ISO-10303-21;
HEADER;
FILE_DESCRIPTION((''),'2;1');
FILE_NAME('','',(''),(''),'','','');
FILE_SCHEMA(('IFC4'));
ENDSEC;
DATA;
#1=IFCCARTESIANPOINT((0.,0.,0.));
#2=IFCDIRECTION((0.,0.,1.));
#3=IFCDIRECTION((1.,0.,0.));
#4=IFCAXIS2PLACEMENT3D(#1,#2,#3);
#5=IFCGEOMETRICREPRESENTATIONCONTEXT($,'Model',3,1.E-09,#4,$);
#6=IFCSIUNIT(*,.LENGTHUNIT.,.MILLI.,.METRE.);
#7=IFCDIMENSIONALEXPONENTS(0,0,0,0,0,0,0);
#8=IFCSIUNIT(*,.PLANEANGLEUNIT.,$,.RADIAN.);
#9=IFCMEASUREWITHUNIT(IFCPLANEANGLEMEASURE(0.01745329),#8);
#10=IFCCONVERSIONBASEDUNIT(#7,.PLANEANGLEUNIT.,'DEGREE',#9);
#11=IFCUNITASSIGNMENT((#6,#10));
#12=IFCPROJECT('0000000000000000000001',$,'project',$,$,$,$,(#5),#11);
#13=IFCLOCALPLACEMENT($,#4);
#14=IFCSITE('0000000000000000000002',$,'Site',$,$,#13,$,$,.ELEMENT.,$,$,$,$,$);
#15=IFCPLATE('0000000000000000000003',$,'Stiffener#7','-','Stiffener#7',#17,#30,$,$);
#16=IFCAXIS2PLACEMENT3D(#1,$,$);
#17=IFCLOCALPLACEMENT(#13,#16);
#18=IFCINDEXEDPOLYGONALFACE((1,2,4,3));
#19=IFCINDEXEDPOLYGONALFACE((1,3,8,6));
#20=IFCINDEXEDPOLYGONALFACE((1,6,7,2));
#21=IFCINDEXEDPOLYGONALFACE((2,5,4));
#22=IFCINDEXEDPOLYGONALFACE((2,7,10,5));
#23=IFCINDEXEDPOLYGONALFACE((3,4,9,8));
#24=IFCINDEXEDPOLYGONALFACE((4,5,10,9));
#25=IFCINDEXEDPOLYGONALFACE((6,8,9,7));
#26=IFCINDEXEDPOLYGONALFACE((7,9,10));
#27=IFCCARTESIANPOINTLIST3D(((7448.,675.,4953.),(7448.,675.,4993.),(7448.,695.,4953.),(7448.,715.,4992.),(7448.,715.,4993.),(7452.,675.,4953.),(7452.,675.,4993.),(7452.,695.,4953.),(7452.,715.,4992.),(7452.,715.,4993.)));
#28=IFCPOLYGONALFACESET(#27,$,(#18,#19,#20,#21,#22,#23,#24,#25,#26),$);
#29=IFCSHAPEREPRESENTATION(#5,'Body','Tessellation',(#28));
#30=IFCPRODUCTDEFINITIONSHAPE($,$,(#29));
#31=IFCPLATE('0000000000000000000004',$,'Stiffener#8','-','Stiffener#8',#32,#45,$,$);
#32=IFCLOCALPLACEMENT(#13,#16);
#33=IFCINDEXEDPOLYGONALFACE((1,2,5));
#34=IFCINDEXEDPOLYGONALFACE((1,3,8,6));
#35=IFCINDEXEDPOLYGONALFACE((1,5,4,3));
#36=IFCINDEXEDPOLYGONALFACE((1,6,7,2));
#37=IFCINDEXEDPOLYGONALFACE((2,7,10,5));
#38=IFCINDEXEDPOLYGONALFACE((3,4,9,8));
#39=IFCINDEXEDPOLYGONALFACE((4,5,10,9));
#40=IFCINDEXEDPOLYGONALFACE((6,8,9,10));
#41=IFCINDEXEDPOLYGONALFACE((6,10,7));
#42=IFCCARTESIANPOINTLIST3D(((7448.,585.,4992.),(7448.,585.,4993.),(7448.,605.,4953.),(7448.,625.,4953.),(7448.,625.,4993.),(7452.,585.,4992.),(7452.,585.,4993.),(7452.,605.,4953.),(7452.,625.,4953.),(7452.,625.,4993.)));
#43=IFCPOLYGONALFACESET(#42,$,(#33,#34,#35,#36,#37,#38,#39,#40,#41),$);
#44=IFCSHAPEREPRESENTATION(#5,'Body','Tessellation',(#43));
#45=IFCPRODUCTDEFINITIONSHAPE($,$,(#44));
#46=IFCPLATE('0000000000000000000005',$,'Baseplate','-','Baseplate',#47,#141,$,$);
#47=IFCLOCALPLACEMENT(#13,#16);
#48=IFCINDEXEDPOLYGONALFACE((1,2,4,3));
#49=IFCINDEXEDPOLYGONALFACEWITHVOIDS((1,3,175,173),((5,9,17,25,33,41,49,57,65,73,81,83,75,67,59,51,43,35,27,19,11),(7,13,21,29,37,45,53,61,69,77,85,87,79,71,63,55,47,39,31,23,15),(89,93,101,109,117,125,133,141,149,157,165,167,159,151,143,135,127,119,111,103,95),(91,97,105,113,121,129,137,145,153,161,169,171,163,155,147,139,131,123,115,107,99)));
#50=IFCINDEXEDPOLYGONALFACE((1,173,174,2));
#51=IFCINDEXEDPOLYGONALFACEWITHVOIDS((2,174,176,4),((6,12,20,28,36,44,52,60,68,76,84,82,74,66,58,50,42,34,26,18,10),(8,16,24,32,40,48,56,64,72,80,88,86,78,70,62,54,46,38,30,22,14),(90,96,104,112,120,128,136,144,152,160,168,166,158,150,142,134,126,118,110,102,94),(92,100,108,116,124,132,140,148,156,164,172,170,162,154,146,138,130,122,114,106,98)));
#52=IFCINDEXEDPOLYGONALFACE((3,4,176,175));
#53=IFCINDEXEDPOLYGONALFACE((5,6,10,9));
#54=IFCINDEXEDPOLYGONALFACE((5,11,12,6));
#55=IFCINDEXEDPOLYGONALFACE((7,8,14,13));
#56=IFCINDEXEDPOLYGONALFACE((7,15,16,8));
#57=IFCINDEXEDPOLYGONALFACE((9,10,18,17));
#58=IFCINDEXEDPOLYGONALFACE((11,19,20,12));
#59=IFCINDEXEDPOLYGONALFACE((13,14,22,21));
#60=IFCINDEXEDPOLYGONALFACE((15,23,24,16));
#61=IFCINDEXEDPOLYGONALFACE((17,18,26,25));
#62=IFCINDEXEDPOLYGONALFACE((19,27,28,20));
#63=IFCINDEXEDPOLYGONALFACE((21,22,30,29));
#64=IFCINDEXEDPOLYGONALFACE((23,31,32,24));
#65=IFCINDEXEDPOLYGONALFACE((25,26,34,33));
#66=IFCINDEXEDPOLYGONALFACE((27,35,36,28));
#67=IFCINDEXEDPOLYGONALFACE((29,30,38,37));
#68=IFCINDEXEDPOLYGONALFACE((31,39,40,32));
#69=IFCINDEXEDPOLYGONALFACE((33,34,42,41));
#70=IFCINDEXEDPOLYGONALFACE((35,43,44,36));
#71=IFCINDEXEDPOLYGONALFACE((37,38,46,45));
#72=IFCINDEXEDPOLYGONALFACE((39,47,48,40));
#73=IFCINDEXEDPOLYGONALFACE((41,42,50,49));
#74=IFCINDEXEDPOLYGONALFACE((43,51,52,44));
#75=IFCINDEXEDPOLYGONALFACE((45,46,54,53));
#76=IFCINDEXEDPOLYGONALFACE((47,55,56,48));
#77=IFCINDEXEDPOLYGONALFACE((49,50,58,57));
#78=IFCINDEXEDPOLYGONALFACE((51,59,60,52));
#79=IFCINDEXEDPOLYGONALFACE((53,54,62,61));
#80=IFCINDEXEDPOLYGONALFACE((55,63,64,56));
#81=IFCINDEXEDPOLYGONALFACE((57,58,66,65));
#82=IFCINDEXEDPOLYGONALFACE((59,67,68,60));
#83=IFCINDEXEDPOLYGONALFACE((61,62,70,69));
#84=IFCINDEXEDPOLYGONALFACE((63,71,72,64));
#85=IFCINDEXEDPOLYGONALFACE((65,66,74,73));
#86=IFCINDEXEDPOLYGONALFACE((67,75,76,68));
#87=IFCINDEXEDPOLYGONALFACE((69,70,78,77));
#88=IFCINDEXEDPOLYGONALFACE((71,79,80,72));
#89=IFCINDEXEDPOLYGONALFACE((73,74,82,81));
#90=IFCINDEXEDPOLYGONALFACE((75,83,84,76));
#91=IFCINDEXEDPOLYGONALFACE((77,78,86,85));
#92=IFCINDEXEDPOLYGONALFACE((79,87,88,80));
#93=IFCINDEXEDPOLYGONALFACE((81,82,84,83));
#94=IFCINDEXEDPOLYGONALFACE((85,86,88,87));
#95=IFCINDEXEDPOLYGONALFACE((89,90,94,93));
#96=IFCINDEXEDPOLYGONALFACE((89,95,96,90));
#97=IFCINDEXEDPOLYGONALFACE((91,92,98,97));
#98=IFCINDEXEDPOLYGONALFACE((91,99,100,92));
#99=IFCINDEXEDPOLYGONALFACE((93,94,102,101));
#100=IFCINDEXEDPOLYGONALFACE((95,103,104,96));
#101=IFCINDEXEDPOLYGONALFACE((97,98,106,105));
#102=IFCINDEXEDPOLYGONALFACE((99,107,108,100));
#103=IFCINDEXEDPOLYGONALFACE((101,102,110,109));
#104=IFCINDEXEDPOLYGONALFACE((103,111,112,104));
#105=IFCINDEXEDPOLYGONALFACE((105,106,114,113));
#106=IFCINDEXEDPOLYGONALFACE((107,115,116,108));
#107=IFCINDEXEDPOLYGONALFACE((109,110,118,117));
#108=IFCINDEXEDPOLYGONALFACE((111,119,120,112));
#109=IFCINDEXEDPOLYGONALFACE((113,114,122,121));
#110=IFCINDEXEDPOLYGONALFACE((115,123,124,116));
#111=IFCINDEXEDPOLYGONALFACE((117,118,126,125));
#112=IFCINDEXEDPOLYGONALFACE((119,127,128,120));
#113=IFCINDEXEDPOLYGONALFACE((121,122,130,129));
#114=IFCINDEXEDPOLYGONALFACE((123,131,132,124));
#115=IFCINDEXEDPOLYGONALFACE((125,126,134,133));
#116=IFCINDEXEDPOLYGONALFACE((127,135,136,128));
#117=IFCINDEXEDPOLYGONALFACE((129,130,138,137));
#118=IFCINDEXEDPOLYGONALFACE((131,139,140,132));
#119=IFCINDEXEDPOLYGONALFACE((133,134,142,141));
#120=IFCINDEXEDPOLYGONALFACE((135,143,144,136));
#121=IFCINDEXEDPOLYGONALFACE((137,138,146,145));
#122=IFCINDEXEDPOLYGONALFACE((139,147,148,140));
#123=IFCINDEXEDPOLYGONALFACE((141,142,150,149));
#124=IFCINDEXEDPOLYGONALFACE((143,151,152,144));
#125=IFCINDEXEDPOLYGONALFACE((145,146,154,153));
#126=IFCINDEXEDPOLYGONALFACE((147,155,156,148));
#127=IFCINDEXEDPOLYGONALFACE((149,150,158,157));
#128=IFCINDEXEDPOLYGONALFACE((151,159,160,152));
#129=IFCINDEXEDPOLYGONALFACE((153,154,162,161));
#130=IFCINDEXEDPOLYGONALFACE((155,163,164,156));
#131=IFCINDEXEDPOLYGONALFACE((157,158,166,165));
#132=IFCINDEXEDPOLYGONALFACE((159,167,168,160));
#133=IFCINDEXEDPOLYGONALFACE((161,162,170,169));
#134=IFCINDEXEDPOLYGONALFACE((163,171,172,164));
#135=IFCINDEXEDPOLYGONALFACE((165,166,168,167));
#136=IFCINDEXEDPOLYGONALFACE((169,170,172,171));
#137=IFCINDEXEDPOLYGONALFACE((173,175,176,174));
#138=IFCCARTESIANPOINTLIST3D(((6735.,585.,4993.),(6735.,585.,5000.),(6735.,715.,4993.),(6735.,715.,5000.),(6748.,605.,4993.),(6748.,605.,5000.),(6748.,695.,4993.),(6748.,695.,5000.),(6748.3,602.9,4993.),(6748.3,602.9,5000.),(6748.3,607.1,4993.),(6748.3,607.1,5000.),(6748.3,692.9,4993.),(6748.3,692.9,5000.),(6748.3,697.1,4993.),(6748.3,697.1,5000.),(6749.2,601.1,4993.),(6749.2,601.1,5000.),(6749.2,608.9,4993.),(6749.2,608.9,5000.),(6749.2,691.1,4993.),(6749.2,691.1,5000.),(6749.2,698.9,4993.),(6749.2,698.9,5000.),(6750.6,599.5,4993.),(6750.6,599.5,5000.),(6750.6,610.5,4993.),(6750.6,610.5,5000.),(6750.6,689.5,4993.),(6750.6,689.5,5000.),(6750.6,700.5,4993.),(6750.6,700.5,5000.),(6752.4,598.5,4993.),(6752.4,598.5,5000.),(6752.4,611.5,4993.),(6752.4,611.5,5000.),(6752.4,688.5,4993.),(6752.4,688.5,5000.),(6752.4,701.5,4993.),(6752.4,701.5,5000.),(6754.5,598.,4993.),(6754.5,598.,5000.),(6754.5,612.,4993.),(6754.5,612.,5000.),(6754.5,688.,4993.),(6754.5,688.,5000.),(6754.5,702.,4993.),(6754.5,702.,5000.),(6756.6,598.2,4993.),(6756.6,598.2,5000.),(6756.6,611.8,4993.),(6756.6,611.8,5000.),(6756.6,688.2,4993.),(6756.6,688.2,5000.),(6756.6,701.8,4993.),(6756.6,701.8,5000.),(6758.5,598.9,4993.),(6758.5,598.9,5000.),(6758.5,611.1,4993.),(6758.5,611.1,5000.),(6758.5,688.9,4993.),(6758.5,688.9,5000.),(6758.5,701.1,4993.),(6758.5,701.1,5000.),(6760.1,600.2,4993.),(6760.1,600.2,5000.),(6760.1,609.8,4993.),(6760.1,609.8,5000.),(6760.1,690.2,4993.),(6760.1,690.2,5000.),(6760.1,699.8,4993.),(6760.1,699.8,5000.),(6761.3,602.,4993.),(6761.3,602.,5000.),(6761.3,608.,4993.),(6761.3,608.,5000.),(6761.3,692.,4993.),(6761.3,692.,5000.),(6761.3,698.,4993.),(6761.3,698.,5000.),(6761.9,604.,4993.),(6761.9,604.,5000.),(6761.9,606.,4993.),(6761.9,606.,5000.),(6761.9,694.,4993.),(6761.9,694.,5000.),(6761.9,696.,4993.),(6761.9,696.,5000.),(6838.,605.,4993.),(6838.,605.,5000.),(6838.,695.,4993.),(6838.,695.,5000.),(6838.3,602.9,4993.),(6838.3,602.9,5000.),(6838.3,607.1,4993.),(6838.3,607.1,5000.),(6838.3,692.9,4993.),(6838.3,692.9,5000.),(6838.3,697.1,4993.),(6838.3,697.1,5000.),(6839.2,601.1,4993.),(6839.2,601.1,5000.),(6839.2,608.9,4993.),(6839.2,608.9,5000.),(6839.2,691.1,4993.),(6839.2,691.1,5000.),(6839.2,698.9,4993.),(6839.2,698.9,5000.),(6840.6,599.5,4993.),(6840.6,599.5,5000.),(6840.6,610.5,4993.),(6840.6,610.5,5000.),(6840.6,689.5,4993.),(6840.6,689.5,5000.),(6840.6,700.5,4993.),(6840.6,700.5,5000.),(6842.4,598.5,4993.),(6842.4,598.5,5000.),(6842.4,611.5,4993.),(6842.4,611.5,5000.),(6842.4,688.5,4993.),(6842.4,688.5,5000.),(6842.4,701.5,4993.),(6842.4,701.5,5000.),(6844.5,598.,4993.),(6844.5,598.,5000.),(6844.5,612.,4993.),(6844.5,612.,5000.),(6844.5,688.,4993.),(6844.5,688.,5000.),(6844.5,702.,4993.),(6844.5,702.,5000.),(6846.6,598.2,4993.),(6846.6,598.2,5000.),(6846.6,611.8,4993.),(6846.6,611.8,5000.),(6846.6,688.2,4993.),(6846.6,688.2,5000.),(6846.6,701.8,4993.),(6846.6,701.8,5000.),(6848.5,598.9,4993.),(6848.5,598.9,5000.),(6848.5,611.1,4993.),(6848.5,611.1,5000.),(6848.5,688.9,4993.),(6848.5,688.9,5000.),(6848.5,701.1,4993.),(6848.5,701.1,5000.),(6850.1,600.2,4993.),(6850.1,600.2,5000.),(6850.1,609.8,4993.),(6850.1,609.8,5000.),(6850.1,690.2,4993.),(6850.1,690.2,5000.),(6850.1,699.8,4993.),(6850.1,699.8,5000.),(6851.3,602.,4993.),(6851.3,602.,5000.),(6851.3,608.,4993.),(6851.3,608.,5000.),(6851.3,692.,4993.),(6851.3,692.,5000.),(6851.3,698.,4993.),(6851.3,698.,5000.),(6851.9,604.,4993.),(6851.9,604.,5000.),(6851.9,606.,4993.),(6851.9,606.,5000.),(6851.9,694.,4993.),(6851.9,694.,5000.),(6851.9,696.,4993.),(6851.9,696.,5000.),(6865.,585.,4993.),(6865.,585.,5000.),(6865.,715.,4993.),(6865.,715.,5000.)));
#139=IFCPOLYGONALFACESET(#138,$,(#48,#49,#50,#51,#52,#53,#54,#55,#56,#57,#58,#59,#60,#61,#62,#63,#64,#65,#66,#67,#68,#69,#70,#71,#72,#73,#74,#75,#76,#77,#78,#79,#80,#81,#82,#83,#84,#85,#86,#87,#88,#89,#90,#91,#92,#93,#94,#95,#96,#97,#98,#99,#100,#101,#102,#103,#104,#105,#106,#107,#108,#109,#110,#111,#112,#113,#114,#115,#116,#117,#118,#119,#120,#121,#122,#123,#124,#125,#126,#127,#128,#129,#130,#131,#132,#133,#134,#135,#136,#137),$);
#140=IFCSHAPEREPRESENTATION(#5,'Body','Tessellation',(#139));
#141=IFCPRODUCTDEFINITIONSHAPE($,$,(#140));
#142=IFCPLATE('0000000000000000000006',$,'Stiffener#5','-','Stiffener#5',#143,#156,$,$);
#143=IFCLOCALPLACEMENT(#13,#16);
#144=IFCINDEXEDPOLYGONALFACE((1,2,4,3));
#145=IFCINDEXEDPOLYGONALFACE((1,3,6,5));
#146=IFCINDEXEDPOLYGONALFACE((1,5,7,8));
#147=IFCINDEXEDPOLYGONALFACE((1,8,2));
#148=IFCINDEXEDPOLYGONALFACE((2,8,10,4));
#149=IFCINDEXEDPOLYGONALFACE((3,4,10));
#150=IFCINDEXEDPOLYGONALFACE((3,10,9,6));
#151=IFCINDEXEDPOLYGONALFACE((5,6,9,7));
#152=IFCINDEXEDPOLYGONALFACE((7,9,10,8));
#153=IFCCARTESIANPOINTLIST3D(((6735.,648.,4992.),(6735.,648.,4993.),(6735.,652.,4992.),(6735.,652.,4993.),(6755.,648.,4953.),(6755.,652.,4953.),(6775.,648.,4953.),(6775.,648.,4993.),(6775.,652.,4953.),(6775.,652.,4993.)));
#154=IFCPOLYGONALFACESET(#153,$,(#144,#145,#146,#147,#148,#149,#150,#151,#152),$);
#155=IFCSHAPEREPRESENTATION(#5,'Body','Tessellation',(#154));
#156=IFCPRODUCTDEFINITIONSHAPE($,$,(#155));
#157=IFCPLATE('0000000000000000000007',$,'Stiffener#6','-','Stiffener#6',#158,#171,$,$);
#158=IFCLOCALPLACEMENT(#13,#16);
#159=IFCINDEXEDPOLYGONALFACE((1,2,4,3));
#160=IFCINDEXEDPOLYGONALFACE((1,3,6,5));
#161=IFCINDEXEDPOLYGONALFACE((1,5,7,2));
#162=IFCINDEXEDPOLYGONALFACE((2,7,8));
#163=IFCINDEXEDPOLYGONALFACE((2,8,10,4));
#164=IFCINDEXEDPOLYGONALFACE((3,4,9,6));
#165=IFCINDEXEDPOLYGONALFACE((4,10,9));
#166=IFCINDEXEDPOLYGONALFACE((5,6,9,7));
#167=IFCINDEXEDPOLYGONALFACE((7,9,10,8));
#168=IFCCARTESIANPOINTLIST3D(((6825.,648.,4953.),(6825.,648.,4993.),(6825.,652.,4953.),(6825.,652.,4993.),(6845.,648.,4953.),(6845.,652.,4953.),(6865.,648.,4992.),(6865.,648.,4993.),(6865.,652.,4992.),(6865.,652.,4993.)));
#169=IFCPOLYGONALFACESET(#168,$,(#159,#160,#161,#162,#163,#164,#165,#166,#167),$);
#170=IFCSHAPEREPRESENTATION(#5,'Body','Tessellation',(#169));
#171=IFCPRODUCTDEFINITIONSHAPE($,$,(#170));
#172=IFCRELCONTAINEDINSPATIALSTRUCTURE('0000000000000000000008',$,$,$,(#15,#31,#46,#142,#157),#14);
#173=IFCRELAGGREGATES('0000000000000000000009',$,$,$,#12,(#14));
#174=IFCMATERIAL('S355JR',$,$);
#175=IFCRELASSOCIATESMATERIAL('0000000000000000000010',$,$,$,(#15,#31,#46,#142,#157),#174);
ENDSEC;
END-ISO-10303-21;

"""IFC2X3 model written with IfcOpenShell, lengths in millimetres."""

from ifc_helpers import new_model, entity, si_unit, converted_unit, frame, frame_2d, origin, origin_with_axes, place, context, project, spatial, polyline, circle, outline, extrude, material, element, save


model = new_model("IFC2X3")

# Units and contexts
model_context = context("Model", 3, precision=1e-09, world=origin_with_axes())
ifc_project = project(units=[si_unit("LENGTHUNIT", "METRE", prefix="MILLI"), converted_unit("PLANEANGLEUNIT", "DEGREE", entity("IfcPlaneAngleMeasure", 0.01745329), si_unit("PLANEANGLEUNIT", "RADIAN"), dimensions=[0, 0, 0, 0, 0, 0, 0])], contexts=[model_context])

# Site
site_placement = place(None, origin_with_axes())
site = spatial("IfcSite", under=ifc_project, at=site_placement, Name="Site", CompositionType="ELEMENT")

# Shared definitions
ifc_material = material(Name="S355JR")

# Plates, openings
plate_1_placement = place(None, frame((7448.0, 675.0, 4993.0), z_axis=(1.0, 0.0, 0.0), x_axis=(0.0, 0.0, -1.0)))
plate_1 = element("IfcPlate", 1, at=plate_1_placement, inside=site, material=ifc_material, Name="Stiffener#7", Description="-", ObjectType="Stiffener#7", context=model_context, shape_type="SweptSolid", body=[
    extrude(outline(polyline([(0.0, 0.0), (40.0, 0.0), (40.0, 40.0), (0.0, 40.0), (0.0, 0.0)])), origin_with_axes(), (0.0, 0.0, 1.0), 4.0),
])
opening_1_placement = place(plate_1_placement, frame((0.0, 0.0, 0.0), z_axis=(0.0, 0.0, 1.0), x_axis=(1.0, 0.0, 0.0)))
element("IfcOpeningElement", 2, at=opening_1_placement, cuts=plate_1, ObjectType="Opening", context=model_context, shape_type="SweptSolid", body=[
    extrude(outline(polyline([(40.0, 40.0), (1.0, 40.0), (40.0, 20.0), (40.0, 40.0)])), origin(), (0.0, 0.0, 1.0), 4.0),
])
plate_2_placement = place(None, frame((7448.0, 625.0, 4993.0), z_axis=(1.0, 0.0, 0.0), x_axis=(0.0, -1.0, 0.0)))
plate_2 = element("IfcPlate", 3, at=plate_2_placement, inside=site, material=ifc_material, Name="Stiffener#8", Description="-", ObjectType="Stiffener#8", context=model_context, shape_type="SweptSolid", body=[
    extrude(outline(polyline([(0.0, 0.0), (40.0, 0.0), (40.0, 40.0), (0.0, 40.0), (0.0, 0.0)])), origin_with_axes(), (0.0, 0.0, 1.0), 4.0),
])
opening_2_placement = place(plate_2_placement, frame((0.0, 0.0, 0.0), z_axis=(0.0, 0.0, 1.0), x_axis=(1.0, 0.0, 0.0)))
element("IfcOpeningElement", 4, at=opening_2_placement, cuts=plate_2, ObjectType="Opening", context=model_context, shape_type="SweptSolid", body=[
    extrude(outline(polyline([(40.0, 40.0), (20.0, 40.0), (40.0, 1.0), (40.0, 40.0)])), origin(), (0.0, 0.0, 1.0), 4.0),
])

# Plate, openings
plate_3_placement = place(None, frame((6865.0, 715.0, 4993.0), z_axis=(0.0, 0.0, 1.0), x_axis=(-1.0, 0.0, 0.0)))
plate_3 = element("IfcPlate", 5, at=plate_3_placement, inside=site, material=ifc_material, Name="Baseplate", Description="-", ObjectType="Baseplate", context=model_context, shape_type="SweptSolid", body=[
    extrude(outline(polyline([(0.0, 0.0), (130.0, 0.0), (130.0, 130.0), (0.0, 130.0), (0.0, 0.0)])), origin_with_axes(), (0.0, 0.0, 1.0), 7.0),
])
opening_3_placement = place(plate_3_placement, frame((110.0, 65.0, 7.5), z_axis=(0.0, 0.0, -1.0), x_axis=(1.0, 0.0, 0.0)))
element("IfcOpeningElement", 6, at=opening_3_placement, cuts=plate_3, ObjectType="Opening", context=model_context, shape_type="SweptSolid", body=[
    extrude(circle(Radius=7.0, at=frame_2d((0.0, 45.0), x_axis=(1.0, 0.0))), origin(), (0.0, 0.0, 1.0), 8.0),
])
opening_4_placement = place(plate_3_placement, frame((110.0, 65.0, 7.5), z_axis=(0.0, 0.0, -1.0), x_axis=(1.0, 0.0, 0.0)))
element("IfcOpeningElement", 7, at=opening_4_placement, cuts=plate_3, ObjectType="Opening", context=model_context, shape_type="SweptSolid", body=[
    extrude(circle(Radius=7.0, at=frame_2d((0.0, -45.0), x_axis=(1.0, 0.0))), origin(), (0.0, 0.0, 1.0), 8.0),
])
opening_5_placement = place(plate_3_placement, frame((20.0, 65.0, 7.5), z_axis=(0.0, 0.0, -1.0), x_axis=(1.0, 0.0, 0.0)))
element("IfcOpeningElement", 8, at=opening_5_placement, cuts=plate_3, ObjectType="Opening", context=model_context, shape_type="SweptSolid", body=[
    extrude(circle(Radius=7.0, at=frame_2d((0.0, 45.0), x_axis=(1.0, 0.0))), origin(), (0.0, 0.0, 1.0), 8.0),
])
opening_6_placement = place(plate_3_placement, frame((20.0, 65.0, 7.5), z_axis=(0.0, 0.0, -1.0), x_axis=(1.0, 0.0, 0.0)))
element("IfcOpeningElement", 9, at=opening_6_placement, cuts=plate_3, ObjectType="Opening", context=model_context, shape_type="SweptSolid", body=[
    extrude(circle(Radius=7.0, at=frame_2d((0.0, -45.0), x_axis=(1.0, 0.0))), origin(), (0.0, 0.0, 1.0), 8.0),
])

# Plates, openings
plate_4_placement = place(None, frame((6775.0, 648.0, 4993.0), z_axis=(0.0, 1.0, 0.0), x_axis=(0.0, 0.0, -1.0)))
plate_4 = element("IfcPlate", 10, at=plate_4_placement, inside=site, material=ifc_material, Name="Stiffener#5", Description="-", ObjectType="Stiffener#5", context=model_context, shape_type="SweptSolid", body=[
    extrude(outline(polyline([(0.0, 0.0), (40.0, 0.0), (40.0, 40.0), (0.0, 40.0), (0.0, 0.0)])), origin_with_axes(), (0.0, 0.0, 1.0), 4.0),
])
opening_7_placement = place(plate_4_placement, frame((0.0, 0.0, 0.0), z_axis=(0.0, 0.0, 1.0), x_axis=(1.0, 0.0, 0.0)))
element("IfcOpeningElement", 11, at=opening_7_placement, cuts=plate_4, ObjectType="Opening", context=model_context, shape_type="SweptSolid", body=[
    extrude(outline(polyline([(40.0, 40.0), (1.0, 40.0), (40.0, 20.0), (40.0, 40.0)])), origin(), (0.0, 0.0, 1.0), 4.0),
])
plate_5_placement = place(None, frame((6825.0, 648.0, 4993.0), z_axis=(0.0, 1.0, 0.0), x_axis=(1.0, 0.0, 0.0)))
plate_5 = element("IfcPlate", 12, at=plate_5_placement, inside=site, material=ifc_material, Name="Stiffener#6", Description="-", ObjectType="Stiffener#6", context=model_context, shape_type="SweptSolid", body=[
    extrude(outline(polyline([(0.0, 0.0), (40.0, 0.0), (40.0, 40.0), (0.0, 40.0), (0.0, 0.0)])), origin_with_axes(), (0.0, 0.0, 1.0), 4.0),
])
opening_8_placement = place(plate_5_placement, frame((0.0, 0.0, 0.0), z_axis=(0.0, 0.0, 1.0), x_axis=(1.0, 0.0, 0.0)))
element("IfcOpeningElement", 13, at=opening_8_placement, cuts=plate_5, ObjectType="Opening", context=model_context, shape_type="SweptSolid", body=[
    extrude(outline(polyline([(40.0, 40.0), (20.0, 40.0), (40.0, 1.0), (40.0, 40.0)])), origin(), (0.0, 0.0, 1.0), 4.0),
])

save(model, "model.ifc")
